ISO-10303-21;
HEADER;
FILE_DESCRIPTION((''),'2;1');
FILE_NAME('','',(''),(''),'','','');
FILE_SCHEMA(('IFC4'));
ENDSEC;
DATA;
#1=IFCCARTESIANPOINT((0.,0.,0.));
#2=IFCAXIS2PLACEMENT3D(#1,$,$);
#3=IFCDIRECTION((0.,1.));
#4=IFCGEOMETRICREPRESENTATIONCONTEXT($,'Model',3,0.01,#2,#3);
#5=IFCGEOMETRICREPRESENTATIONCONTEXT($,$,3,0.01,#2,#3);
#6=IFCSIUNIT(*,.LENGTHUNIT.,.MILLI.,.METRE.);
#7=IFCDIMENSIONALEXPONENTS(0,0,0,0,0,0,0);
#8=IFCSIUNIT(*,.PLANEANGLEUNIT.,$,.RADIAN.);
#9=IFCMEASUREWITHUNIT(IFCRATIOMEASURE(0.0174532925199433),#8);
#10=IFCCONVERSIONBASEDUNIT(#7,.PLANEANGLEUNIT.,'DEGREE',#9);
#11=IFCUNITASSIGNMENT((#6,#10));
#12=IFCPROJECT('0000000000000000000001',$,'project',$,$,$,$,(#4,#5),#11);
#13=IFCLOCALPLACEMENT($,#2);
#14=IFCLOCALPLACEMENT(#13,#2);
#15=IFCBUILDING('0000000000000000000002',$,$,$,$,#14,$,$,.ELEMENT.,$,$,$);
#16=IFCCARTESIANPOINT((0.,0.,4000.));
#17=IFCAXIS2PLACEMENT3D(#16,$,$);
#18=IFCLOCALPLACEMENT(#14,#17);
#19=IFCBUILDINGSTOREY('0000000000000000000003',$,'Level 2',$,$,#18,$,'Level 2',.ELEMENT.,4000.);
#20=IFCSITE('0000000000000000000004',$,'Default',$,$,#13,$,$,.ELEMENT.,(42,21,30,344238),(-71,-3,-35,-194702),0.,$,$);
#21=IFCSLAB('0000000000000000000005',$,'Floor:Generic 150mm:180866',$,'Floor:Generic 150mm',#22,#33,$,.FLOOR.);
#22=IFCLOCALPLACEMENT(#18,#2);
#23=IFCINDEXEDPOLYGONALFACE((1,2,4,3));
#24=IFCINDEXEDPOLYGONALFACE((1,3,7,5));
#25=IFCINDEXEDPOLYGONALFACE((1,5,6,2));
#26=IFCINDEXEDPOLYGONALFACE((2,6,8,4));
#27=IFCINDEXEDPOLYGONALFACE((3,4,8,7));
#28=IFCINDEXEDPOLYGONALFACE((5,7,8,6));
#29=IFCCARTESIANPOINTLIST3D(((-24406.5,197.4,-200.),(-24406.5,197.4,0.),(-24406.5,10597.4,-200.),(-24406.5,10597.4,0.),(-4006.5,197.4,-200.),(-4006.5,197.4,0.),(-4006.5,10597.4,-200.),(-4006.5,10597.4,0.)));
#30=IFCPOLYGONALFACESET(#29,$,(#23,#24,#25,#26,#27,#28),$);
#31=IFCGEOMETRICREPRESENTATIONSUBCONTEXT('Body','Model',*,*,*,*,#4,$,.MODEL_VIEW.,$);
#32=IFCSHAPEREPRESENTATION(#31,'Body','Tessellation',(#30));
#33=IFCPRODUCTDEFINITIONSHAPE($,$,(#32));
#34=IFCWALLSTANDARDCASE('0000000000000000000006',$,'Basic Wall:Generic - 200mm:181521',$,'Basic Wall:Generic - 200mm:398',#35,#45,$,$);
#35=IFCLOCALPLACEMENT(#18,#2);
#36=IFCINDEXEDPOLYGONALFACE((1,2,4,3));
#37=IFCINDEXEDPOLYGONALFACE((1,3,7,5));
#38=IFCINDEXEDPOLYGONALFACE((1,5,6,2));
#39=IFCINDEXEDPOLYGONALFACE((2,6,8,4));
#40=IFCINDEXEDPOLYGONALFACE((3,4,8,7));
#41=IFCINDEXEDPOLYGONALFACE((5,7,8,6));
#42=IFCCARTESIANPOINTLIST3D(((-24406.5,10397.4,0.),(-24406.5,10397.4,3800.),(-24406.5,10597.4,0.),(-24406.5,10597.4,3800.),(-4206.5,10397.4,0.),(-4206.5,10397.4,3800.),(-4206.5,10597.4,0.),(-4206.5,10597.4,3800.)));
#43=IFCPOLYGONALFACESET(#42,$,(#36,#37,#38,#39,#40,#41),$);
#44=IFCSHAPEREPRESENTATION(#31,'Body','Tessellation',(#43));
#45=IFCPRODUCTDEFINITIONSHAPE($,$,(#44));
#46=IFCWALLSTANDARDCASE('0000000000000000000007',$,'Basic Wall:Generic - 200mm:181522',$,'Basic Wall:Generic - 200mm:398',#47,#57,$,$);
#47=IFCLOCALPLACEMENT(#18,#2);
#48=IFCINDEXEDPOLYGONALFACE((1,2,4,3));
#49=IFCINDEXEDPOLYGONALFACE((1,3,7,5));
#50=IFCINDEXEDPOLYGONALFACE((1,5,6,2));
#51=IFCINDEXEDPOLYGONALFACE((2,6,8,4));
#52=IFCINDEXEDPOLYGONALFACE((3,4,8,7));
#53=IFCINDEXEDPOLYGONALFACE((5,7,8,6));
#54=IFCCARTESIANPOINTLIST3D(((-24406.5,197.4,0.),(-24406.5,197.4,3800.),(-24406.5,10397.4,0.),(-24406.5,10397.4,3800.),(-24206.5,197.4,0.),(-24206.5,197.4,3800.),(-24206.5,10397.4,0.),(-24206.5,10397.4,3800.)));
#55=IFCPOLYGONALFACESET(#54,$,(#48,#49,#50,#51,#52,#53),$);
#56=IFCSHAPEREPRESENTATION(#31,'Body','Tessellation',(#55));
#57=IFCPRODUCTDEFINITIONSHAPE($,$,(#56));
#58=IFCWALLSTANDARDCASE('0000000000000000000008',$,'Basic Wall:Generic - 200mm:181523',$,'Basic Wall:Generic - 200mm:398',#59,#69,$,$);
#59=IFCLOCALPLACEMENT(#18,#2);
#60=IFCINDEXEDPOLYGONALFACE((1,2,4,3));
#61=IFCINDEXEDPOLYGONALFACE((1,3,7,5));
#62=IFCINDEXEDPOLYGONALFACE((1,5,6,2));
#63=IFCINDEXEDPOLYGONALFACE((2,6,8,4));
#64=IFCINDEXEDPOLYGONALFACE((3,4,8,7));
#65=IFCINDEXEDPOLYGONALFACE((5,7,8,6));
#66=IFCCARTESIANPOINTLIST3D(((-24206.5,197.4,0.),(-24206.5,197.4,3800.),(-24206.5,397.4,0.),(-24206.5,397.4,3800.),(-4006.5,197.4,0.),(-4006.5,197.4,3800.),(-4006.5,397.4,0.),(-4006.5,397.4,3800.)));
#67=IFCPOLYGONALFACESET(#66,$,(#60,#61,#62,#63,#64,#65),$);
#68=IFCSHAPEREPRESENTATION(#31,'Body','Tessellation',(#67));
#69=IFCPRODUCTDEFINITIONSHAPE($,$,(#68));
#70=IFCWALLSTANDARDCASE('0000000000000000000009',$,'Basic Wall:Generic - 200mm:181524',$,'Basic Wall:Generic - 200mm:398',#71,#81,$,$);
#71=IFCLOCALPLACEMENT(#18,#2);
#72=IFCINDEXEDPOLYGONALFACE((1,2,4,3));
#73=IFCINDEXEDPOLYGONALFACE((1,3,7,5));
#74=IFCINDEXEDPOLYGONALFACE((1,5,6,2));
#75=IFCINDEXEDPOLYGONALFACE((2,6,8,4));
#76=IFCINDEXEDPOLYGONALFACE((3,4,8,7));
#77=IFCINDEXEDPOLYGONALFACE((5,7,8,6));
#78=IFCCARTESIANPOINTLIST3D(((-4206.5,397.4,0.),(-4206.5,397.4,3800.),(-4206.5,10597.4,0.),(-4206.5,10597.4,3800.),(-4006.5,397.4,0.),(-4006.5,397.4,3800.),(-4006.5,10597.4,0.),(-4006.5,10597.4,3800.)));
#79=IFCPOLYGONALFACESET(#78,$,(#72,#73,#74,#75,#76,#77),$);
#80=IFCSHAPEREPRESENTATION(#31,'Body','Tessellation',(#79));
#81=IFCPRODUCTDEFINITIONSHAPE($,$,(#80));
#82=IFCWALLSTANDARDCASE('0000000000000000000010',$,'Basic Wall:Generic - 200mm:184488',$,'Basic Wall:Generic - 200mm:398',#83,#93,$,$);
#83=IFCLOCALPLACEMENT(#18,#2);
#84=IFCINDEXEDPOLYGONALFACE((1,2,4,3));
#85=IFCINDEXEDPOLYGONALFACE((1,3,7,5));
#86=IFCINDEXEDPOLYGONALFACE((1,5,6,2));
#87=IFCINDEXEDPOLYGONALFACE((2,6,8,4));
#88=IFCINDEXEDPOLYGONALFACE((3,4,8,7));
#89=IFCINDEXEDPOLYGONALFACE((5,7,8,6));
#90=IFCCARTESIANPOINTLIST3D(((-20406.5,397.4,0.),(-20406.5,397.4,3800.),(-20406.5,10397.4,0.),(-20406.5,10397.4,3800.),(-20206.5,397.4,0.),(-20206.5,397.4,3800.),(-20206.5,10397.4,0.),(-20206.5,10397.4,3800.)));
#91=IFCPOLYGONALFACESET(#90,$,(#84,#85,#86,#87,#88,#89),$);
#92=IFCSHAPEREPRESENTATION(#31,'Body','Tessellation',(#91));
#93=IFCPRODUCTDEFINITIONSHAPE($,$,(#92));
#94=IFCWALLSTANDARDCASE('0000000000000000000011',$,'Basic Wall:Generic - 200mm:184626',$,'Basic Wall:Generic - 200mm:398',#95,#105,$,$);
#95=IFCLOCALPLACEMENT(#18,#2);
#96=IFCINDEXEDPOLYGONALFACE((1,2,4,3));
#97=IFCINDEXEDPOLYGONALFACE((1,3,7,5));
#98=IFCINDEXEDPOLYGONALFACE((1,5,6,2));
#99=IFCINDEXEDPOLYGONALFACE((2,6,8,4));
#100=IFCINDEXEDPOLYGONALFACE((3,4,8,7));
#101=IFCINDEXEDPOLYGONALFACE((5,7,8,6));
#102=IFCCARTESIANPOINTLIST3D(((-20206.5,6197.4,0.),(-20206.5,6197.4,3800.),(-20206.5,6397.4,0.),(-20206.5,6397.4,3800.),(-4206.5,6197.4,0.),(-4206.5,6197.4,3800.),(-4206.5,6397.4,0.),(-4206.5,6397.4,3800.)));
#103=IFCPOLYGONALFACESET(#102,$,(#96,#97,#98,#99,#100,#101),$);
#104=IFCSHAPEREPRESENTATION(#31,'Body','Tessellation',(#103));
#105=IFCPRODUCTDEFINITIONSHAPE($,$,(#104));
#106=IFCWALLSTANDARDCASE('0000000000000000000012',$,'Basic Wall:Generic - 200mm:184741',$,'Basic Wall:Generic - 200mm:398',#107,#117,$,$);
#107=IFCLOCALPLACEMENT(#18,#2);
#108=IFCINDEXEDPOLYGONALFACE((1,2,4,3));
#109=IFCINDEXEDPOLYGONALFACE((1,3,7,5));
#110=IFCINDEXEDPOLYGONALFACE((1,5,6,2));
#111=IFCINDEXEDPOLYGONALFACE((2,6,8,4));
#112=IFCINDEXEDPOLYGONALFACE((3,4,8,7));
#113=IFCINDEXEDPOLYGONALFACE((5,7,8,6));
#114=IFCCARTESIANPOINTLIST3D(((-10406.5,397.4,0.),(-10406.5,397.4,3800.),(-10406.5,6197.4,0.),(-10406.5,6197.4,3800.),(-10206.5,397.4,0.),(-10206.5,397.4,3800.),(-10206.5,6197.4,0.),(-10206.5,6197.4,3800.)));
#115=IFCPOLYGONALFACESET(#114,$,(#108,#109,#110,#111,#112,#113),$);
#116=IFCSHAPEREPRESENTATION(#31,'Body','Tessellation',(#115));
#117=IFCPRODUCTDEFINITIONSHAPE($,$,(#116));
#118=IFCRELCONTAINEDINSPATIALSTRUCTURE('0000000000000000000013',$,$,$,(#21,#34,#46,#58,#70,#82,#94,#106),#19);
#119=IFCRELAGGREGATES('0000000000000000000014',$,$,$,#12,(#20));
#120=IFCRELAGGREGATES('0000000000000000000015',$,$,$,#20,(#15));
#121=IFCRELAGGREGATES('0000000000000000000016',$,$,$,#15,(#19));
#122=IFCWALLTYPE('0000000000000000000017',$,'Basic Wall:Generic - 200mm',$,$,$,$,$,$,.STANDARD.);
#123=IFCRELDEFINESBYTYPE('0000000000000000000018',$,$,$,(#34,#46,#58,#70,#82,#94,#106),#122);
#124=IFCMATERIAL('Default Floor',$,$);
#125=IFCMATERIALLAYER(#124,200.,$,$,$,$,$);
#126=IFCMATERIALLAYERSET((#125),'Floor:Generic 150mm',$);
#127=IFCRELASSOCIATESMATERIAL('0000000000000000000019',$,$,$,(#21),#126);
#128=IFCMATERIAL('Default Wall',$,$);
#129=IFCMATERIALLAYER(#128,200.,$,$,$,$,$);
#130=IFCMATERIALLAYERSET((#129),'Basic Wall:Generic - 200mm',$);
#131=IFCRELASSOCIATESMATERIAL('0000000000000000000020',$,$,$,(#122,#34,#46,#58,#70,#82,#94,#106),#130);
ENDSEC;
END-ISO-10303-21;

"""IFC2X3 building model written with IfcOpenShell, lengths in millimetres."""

from ifc_helpers import new_model, entity, si_unit, converted_unit, direction, frame, frame_2d, origin, origin_2d_with_axis, place, context, subcontext, project, spatial, rectangle, extrude, material, layer, layer_set, layer_usage, type_object, element, save


model = new_model("IFC2X3")

# Units and contexts
model_context = context("Model", 3, precision=0.01, world=origin(), true_north=direction((0.0, 1.0)))
context_of_model = context(None, 3, precision=0.01, world=origin(), true_north=direction((0.0, 1.0)))
body_context = subcontext(model_context, "Body", "Model", "MODEL_VIEW")
ifc_project = project(units=[si_unit("LENGTHUNIT", "METRE", prefix="MILLI"), converted_unit("PLANEANGLEUNIT", "DEGREE", entity("IfcRatioMeasure", 0.0174532925199433), si_unit("PLANEANGLEUNIT", "RADIAN"), dimensions=[0, 0, 0, 0, 0, 0, 0])], contexts=[model_context, context_of_model])

# Site, building, storey
site_placement = place(None, origin())
site = spatial("IfcSite", under=ifc_project, at=site_placement, Name="Default", CompositionType="ELEMENT", RefLatitude=(42, 21, 30, 344238), RefLongitude=(-71, -3, -35, -194702), RefElevation=0.0)
building_placement = place(site_placement, origin())
building = spatial("IfcBuilding", under=site, at=building_placement, CompositionType="ELEMENT")
storey_placement = place(building_placement, frame((0.0, 0.0, 4000.0)))
storey = spatial("IfcBuildingStorey", under=building, at=storey_placement, Name="Level 2", LongName="Level 2", CompositionType="ELEMENT", Elevation=4000.0)

# Slab
ifc_material_1 = material(Name="Default Floor")
ifc_layer_1 = layer(ifc_material_1, 200.0)
ifc_layer_set_1 = layer_set([ifc_layer_1], Name="Floor:Generic 150mm")
ifc_layer_usage_1 = layer_usage(ifc_layer_set_1, "AXIS3", "POSITIVE", 0.0)
slab_placement = place(storey_placement, origin())
element("IfcSlab", 1, at=slab_placement, inside=storey, material=ifc_layer_usage_1, Name="Floor:Generic 150mm:180866", ObjectType="Floor:Generic 150mm", PredefinedType="FLOOR", context=body_context, shape_type="SweptSolid", body=[
    extrude(rectangle(XDim=10400.0, YDim=20400.0, at=origin_2d_with_axis()), frame((-14206.5, 5397.4, 0.0), z_axis=(0.0, 0.0, -1.0), x_axis=(0.0, 1.0, 0.0)), (0.0, 0.0, 1.0), 200.0),
])

# Walls
ifc_material_2 = material(Name="Default Wall")
ifc_layer_2 = layer(ifc_material_2, 200.0)
ifc_layer_set_2 = layer_set([ifc_layer_2], Name="Basic Wall:Generic - 200mm")
ifc_layer_usage_2 = layer_usage(ifc_layer_set_2, "AXIS2", "NEGATIVE", 100.0)
wall_type = type_object("IfcWallType", Name="Basic Wall:Generic - 200mm", PredefinedType="STANDARD", material=ifc_layer_set_2)
wall_1_placement = place(storey_placement, frame((-24406.5, 10497.4, 0.0)))
element("IfcWallStandardCase", 2, at=wall_1_placement, inside=storey, type_object=wall_type, material=ifc_layer_usage_2, Name="Basic Wall:Generic - 200mm:181521", ObjectType="Basic Wall:Generic - 200mm:398", context=body_context, shape_type="SweptSolid", body=[
    extrude(rectangle(XDim=20200.0, YDim=200.0, at=frame_2d((10100.0, 0.0), x_axis=(-1.0, 0.0))), origin(), (0.0, 0.0, 1.0), 3800.0),
])
ifc_layer_usage_3 = layer_usage(ifc_layer_set_2, "AXIS2", "NEGATIVE", 100.0)
wall_2_placement = place(storey_placement, frame((-24306.5, 197.4, 0.0), z_axis=(0.0, 0.0, 1.0), x_axis=(0.0, 1.0, 0.0)))
element("IfcWallStandardCase", 3, at=wall_2_placement, inside=storey, type_object=wall_type, material=ifc_layer_usage_3, Name="Basic Wall:Generic - 200mm:181522", ObjectType="Basic Wall:Generic - 200mm:398", context=body_context, shape_type="SweptSolid", body=[
    extrude(rectangle(XDim=10200.0, YDim=200.0, at=frame_2d((5100.0, 0.0), x_axis=(-1.0, 0.0))), origin(), (0.0, 0.0, 1.0), 3800.0),
])
ifc_layer_usage_4 = layer_usage(ifc_layer_set_2, "AXIS2", "NEGATIVE", 100.0)
wall_3_placement = place(storey_placement, frame((-4006.5, 297.4, 0.0), z_axis=(0.0, 0.0, 1.0), x_axis=(-1.0, 0.0, 0.0)))
element("IfcWallStandardCase", 4, at=wall_3_placement, inside=storey, type_object=wall_type, material=ifc_layer_usage_4, Name="Basic Wall:Generic - 200mm:181523", ObjectType="Basic Wall:Generic - 200mm:398", context=body_context, shape_type="SweptSolid", body=[
    extrude(rectangle(XDim=20200.0, YDim=200.0, at=frame_2d((10100.0, 0.0), x_axis=(-1.0, 0.0))), origin(), (0.0, 0.0, 1.0), 3800.0),
])
ifc_layer_usage_5 = layer_usage(ifc_layer_set_2, "AXIS2", "NEGATIVE", 100.0)
wall_4_placement = place(storey_placement, frame((-4106.5, 10597.4, 0.0), z_axis=(0.0, 0.0, 1.0), x_axis=(0.0, -1.0, 0.0)))
element("IfcWallStandardCase", 5, at=wall_4_placement, inside=storey, type_object=wall_type, material=ifc_layer_usage_5, Name="Basic Wall:Generic - 200mm:181524", ObjectType="Basic Wall:Generic - 200mm:398", context=body_context, shape_type="SweptSolid", body=[
    extrude(rectangle(XDim=10200.0, YDim=200.0, at=frame_2d((5100.0, 0.0), x_axis=(-1.0, 0.0))), origin(), (0.0, 0.0, 1.0), 3800.0),
])
ifc_layer_usage_6 = layer_usage(ifc_layer_set_2, "AXIS2", "NEGATIVE", 100.0)
wall_5_placement = place(storey_placement, frame((-20306.5, 10397.4, 0.0), z_axis=(0.0, 0.0, 1.0), x_axis=(0.0, -1.0, 0.0)))
element("IfcWallStandardCase", 6, at=wall_5_placement, inside=storey, type_object=wall_type, material=ifc_layer_usage_6, Name="Basic Wall:Generic - 200mm:184488", ObjectType="Basic Wall:Generic - 200mm:398", context=body_context, shape_type="SweptSolid", body=[
    extrude(rectangle(XDim=10000.0, YDim=200.0, at=frame_2d((5000.0, 0.0), x_axis=(-1.0, 0.0))), origin(), (0.0, 0.0, 1.0), 3800.0),
])
ifc_layer_usage_7 = layer_usage(ifc_layer_set_2, "AXIS2", "NEGATIVE", 100.0)
wall_6_placement = place(storey_placement, frame((-20206.5, 6297.4, 0.0)))
element("IfcWallStandardCase", 7, at=wall_6_placement, inside=storey, type_object=wall_type, material=ifc_layer_usage_7, Name="Basic Wall:Generic - 200mm:184626", ObjectType="Basic Wall:Generic - 200mm:398", context=body_context, shape_type="SweptSolid", body=[
    extrude(rectangle(XDim=16000.0, YDim=200.0, at=frame_2d((8000.0, 0.0), x_axis=(-1.0, 0.0))), origin(), (0.0, 0.0, 1.0), 3800.0),
])
ifc_layer_usage_8 = layer_usage(ifc_layer_set_2, "AXIS2", "NEGATIVE", 100.0)
wall_7_placement = place(storey_placement, frame((-10306.5, 397.4, 0.0), z_axis=(0.0, 0.0, 1.0), x_axis=(0.0, 1.0, 0.0)))
element("IfcWallStandardCase", 8, at=wall_7_placement, inside=storey, type_object=wall_type, material=ifc_layer_usage_8, Name="Basic Wall:Generic - 200mm:184741", ObjectType="Basic Wall:Generic - 200mm:398", context=body_context, shape_type="SweptSolid", body=[
    extrude(rectangle(XDim=5800.0, YDim=200.0, at=frame_2d((2900.0, 0.0), x_axis=(-1.0, 0.0))), origin(), (0.0, 0.0, 1.0), 3800.0),
])

save(model, "model.ifc")
